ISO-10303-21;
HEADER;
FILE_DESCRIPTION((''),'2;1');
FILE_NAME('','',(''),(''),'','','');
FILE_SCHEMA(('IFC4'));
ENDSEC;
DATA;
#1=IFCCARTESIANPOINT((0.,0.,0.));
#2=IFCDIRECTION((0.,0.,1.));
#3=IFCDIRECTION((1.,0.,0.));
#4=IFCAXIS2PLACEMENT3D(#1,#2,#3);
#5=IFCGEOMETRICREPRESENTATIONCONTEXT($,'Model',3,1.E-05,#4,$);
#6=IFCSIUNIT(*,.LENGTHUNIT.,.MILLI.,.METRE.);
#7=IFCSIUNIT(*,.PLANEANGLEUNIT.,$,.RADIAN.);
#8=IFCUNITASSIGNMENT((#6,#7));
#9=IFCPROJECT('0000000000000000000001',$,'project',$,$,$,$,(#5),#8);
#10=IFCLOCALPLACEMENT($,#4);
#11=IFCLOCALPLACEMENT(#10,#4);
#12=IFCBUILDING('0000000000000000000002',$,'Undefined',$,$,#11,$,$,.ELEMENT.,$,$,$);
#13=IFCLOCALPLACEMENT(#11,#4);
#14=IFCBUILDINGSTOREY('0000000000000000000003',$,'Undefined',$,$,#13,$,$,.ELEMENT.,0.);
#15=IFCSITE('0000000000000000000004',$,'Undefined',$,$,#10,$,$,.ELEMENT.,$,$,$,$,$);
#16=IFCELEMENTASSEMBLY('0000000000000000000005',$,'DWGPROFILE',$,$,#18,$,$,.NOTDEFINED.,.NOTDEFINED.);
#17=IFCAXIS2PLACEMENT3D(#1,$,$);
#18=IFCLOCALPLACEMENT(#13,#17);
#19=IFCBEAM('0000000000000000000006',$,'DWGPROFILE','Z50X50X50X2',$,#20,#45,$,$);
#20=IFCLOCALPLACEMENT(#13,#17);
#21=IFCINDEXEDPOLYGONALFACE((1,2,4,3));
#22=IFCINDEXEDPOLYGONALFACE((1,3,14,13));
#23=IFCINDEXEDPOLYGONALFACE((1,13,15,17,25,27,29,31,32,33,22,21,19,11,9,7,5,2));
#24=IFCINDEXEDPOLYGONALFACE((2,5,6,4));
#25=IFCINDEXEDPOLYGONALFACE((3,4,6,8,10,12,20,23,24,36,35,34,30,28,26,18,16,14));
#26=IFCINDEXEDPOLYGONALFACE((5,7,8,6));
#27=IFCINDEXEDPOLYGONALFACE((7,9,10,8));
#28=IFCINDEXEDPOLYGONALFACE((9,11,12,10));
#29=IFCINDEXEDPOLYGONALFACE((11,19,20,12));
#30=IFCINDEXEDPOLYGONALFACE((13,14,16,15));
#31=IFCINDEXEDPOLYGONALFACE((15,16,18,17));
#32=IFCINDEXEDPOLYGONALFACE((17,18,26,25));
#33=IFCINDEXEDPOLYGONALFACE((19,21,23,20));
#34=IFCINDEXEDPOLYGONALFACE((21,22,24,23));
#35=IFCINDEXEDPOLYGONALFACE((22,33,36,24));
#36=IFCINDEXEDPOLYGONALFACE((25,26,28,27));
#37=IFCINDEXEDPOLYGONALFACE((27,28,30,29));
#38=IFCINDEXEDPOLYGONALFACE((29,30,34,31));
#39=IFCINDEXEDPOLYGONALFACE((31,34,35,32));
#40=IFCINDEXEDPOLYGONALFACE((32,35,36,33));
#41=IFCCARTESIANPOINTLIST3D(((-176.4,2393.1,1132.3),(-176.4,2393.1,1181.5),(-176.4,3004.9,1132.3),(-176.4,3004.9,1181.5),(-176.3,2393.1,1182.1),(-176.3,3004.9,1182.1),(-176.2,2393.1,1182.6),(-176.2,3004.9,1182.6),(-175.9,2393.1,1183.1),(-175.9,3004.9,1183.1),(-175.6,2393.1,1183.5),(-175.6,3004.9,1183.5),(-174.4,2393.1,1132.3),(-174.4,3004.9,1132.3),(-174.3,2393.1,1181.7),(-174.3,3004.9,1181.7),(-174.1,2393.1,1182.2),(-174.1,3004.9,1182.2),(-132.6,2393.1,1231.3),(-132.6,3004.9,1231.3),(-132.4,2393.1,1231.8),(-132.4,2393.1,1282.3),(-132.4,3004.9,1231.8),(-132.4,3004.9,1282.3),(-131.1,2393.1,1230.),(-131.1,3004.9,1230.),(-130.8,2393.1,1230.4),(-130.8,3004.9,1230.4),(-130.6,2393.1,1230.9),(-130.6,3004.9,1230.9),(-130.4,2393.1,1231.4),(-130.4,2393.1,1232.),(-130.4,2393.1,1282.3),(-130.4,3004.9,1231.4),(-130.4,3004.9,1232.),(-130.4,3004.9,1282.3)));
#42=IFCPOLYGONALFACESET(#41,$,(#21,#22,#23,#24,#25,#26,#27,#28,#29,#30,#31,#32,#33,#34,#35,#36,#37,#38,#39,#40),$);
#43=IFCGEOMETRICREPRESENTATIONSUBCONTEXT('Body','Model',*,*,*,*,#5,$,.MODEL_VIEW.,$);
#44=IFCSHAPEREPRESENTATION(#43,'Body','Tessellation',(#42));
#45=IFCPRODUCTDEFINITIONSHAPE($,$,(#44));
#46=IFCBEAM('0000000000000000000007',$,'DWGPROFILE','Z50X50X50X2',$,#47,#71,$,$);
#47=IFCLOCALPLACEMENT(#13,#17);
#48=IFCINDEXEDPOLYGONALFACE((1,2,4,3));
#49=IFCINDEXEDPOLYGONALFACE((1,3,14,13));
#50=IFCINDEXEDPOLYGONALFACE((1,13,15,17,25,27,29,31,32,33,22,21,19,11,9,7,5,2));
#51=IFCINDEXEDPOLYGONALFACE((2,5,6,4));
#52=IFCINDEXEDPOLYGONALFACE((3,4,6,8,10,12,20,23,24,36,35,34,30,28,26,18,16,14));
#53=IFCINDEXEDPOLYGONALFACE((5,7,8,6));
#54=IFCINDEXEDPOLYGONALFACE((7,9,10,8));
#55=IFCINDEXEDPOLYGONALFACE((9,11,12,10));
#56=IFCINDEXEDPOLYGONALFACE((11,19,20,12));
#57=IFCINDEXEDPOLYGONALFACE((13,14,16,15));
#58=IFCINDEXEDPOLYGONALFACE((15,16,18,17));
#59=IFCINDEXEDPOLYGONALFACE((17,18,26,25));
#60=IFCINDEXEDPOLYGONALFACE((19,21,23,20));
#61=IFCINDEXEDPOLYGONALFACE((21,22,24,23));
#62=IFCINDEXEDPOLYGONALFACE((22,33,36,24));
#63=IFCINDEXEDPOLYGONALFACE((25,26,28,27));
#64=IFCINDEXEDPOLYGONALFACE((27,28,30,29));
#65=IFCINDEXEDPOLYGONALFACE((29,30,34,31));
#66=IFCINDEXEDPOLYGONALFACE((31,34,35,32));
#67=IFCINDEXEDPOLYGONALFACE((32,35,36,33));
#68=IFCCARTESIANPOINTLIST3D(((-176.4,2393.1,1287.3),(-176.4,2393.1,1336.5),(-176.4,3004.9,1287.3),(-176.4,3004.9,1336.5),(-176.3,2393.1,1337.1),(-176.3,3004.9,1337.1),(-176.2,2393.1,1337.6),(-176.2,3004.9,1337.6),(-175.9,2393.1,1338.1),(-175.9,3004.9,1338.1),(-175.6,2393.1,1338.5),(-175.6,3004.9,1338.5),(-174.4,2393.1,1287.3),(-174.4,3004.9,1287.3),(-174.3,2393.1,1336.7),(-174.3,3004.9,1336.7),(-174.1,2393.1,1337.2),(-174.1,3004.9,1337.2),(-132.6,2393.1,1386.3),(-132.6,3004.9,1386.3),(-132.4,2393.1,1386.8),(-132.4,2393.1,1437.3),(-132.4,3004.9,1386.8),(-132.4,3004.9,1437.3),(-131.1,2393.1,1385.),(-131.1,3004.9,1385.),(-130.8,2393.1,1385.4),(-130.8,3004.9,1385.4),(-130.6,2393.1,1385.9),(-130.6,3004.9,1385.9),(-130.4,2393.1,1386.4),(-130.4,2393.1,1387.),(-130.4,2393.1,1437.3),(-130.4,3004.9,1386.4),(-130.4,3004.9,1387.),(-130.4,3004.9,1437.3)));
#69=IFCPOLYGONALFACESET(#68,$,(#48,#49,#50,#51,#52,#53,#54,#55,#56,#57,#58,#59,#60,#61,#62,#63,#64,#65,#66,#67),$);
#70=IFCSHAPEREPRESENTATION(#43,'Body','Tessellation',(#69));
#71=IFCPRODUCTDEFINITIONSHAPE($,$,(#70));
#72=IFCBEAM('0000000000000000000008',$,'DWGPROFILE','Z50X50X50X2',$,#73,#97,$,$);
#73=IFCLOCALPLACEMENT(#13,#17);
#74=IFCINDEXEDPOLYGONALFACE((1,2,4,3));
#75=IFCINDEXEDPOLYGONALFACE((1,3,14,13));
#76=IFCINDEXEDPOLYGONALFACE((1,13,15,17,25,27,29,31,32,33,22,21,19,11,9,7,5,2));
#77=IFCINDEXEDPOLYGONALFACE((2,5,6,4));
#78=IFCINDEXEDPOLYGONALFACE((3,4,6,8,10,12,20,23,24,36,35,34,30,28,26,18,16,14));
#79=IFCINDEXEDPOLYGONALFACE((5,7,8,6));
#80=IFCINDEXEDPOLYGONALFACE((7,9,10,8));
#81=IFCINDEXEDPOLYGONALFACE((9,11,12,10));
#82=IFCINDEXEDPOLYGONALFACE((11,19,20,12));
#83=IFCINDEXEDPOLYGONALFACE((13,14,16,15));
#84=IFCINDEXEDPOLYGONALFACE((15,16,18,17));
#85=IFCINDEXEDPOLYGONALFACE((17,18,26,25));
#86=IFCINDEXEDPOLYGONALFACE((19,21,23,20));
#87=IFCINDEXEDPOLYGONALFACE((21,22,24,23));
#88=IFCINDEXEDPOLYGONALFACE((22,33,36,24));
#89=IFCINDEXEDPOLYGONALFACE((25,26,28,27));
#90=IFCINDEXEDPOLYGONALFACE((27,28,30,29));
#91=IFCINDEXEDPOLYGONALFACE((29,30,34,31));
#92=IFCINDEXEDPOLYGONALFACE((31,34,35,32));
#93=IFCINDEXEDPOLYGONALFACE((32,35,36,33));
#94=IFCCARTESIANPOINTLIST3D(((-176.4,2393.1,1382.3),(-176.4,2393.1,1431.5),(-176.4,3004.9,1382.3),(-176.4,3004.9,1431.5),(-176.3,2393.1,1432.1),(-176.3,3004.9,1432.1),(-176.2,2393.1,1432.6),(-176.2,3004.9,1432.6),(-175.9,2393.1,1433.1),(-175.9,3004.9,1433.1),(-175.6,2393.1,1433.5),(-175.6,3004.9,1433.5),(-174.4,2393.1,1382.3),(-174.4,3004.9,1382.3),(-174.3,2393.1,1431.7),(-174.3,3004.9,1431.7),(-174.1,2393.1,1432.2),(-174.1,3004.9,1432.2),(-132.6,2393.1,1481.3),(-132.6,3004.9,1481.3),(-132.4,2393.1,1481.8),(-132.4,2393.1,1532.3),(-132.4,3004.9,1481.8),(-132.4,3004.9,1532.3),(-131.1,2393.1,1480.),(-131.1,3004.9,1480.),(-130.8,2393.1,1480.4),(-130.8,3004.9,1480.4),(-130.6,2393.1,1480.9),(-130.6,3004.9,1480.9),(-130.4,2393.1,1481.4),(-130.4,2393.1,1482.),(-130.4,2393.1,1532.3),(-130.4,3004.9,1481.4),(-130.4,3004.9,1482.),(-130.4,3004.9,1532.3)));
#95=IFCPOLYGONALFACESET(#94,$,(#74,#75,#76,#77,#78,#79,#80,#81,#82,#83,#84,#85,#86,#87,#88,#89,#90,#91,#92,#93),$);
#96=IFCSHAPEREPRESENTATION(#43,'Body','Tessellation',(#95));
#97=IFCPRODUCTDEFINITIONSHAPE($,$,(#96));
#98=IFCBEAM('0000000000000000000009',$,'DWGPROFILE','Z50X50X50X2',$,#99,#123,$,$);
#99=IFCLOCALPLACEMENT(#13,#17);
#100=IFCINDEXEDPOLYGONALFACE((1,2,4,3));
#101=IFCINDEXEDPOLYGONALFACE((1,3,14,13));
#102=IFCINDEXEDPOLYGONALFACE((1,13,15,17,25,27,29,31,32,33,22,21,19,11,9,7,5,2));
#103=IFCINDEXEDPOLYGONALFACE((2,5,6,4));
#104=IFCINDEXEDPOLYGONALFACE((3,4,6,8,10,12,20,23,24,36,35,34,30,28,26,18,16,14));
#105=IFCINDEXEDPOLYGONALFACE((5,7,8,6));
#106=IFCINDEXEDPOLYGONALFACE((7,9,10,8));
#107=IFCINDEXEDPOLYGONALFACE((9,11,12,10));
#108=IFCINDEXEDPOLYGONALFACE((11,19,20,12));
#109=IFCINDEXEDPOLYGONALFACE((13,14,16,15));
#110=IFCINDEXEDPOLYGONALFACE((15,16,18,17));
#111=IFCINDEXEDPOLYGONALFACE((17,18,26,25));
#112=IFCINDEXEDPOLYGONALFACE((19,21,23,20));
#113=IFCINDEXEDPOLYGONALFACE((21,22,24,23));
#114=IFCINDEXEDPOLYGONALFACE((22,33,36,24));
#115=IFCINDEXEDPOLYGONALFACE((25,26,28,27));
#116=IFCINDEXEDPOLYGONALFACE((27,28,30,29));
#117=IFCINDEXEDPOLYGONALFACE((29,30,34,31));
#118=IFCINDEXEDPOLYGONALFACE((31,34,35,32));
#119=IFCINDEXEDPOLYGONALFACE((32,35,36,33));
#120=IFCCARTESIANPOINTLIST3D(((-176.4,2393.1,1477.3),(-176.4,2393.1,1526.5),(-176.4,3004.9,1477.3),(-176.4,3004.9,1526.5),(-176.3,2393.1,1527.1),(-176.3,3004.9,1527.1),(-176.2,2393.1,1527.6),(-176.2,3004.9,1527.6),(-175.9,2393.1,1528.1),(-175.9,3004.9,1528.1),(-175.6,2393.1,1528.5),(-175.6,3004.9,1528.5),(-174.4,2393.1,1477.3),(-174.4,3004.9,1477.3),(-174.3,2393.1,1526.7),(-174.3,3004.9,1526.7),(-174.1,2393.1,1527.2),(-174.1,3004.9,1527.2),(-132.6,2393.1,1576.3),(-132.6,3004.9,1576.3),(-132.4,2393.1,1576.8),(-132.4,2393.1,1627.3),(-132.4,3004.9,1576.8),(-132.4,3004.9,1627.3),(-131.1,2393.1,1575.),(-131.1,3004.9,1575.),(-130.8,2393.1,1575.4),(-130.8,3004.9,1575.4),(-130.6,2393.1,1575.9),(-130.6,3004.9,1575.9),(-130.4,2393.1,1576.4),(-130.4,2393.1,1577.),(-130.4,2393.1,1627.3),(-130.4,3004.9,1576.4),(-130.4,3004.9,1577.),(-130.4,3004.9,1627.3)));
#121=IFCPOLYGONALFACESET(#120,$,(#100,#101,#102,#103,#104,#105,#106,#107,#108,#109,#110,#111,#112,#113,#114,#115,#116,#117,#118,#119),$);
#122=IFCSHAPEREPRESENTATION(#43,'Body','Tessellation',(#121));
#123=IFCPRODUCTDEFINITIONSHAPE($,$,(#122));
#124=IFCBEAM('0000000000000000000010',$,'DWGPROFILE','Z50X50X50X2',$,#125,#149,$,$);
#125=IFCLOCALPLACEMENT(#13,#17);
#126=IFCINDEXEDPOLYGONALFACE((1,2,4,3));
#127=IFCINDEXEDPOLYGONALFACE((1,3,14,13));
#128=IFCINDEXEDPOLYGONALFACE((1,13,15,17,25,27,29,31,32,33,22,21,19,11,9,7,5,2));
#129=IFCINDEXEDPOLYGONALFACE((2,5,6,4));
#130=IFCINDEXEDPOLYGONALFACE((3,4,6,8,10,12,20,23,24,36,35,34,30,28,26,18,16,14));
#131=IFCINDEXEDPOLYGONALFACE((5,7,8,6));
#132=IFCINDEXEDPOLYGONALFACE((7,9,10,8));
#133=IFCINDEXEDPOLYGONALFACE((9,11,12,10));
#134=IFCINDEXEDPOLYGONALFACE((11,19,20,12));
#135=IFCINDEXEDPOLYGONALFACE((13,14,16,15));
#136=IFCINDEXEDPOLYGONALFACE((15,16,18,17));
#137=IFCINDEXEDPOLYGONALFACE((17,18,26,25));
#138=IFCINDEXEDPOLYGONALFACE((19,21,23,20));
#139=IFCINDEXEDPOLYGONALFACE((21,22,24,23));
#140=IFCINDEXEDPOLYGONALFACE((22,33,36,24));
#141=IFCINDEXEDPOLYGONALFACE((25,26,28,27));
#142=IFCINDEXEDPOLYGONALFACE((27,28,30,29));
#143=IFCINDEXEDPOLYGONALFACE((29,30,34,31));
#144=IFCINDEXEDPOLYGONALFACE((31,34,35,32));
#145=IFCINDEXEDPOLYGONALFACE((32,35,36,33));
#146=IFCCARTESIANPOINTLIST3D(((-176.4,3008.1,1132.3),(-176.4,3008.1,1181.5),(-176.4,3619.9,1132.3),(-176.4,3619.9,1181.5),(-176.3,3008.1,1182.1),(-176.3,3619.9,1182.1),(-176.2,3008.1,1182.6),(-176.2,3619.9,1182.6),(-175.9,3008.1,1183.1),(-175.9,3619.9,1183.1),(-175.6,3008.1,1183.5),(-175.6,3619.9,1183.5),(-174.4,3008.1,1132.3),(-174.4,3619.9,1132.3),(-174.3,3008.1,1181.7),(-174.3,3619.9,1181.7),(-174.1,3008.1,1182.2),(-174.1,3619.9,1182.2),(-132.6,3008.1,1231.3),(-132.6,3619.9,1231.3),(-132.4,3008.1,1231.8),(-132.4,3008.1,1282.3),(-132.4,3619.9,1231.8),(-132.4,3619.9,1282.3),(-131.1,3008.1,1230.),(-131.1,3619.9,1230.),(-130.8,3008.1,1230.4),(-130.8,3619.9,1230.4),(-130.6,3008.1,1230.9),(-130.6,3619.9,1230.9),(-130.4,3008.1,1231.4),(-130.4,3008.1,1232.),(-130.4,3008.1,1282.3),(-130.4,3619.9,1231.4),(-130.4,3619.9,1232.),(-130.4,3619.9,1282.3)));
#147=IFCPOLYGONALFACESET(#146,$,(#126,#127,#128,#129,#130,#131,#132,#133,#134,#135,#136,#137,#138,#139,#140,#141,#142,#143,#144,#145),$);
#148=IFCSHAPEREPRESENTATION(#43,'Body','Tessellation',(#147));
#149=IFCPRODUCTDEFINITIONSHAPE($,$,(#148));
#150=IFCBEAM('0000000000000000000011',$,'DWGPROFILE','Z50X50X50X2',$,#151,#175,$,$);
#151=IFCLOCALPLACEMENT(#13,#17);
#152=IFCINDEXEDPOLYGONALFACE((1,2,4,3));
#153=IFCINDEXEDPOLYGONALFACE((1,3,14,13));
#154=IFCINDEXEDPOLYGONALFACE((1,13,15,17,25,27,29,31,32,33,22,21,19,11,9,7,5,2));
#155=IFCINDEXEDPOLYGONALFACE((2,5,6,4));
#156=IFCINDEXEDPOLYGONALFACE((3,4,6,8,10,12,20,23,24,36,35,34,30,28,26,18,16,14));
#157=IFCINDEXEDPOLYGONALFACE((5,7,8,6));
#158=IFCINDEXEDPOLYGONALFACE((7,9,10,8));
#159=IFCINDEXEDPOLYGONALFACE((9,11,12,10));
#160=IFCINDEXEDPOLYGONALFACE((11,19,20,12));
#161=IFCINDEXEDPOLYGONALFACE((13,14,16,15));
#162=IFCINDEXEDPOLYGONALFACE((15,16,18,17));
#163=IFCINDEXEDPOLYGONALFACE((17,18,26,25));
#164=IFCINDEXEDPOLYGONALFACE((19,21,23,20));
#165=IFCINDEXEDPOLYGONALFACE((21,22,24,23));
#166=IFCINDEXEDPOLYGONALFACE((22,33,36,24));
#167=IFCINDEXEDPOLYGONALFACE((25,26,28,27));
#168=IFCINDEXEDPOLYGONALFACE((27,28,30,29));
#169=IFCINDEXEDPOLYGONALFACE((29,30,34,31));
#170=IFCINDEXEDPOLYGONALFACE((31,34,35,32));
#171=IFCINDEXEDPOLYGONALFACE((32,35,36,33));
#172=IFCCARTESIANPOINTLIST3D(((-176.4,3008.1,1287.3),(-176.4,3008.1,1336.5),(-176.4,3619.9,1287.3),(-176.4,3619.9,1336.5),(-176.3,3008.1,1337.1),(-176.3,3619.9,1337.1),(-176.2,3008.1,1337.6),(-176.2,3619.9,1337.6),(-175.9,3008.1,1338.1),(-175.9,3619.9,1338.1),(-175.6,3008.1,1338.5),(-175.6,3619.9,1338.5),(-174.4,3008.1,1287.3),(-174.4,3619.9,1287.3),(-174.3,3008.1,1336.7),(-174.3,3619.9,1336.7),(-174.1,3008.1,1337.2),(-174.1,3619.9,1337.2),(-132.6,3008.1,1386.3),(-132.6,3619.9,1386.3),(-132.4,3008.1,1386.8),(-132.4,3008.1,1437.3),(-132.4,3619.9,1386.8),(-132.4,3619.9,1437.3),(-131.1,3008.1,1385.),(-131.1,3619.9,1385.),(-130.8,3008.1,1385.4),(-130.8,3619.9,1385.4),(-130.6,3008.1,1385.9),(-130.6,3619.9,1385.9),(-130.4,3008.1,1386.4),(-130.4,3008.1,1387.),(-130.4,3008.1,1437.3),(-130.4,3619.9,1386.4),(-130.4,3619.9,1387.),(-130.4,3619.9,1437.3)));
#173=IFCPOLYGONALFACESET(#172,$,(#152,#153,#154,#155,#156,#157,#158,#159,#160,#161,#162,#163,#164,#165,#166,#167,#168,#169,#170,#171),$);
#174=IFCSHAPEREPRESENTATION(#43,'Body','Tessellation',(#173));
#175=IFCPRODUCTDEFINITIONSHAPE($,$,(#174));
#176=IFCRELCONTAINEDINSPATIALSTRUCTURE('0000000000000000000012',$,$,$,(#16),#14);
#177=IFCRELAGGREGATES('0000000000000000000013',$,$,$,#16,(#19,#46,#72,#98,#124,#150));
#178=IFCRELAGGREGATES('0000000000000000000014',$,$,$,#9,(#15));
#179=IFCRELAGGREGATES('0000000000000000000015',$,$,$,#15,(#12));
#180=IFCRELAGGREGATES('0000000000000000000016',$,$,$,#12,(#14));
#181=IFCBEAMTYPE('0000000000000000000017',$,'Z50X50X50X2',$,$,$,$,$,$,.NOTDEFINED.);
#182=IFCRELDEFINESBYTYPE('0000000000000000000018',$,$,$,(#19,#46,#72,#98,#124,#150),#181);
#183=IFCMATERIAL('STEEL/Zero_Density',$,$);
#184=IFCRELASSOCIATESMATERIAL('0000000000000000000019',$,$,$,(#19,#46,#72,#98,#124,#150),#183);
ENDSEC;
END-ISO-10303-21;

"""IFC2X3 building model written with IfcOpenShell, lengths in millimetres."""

from ifc_helpers import new_model, si_unit, frame, origin_with_axes, place, context, subcontext, project, spatial, polyline, outline, extrude, material, type_object, element, aggregate, save


model = new_model("IFC2X3")

# Units and contexts
model_context = context("Model", 3, precision=1e-05, world=origin_with_axes())
body_context = subcontext(model_context, "Body", "Model", "MODEL_VIEW")
ifc_project = project(units=[si_unit("LENGTHUNIT", "METRE", prefix="MILLI"), si_unit("PLANEANGLEUNIT", "RADIAN")], contexts=[model_context])

# Site, building, storey
site_placement = place(None, origin_with_axes())
site = spatial("IfcSite", under=ifc_project, at=site_placement, Name="Undefined", CompositionType="ELEMENT")
building_placement = place(site_placement, origin_with_axes())
building = spatial("IfcBuilding", under=site, at=building_placement, Name="Undefined", CompositionType="ELEMENT")
storey_placement = place(building_placement, origin_with_axes())
storey = spatial("IfcBuildingStorey", under=building, at=storey_placement, Name="Undefined", CompositionType="ELEMENT", Elevation=0.0)

# Element assembly, beams
assembly_1_placement = place(storey_placement, origin_with_axes())
assembly_1 = element("IfcElementAssembly", 1, at=assembly_1_placement, inside=storey, Name="DWGPROFILE", AssemblyPlace="NOTDEFINED", PredefinedType="NOTDEFINED")
ifc_material_1 = material(Name="STEEL/Zero_Density")
beam_type_1 = type_object("IfcBeamType", Name="Z50X50X50X2", PredefinedType="NOTDEFINED")
beam_1_placement = place(assembly_1_placement, frame((-153.4, 3004.9, 1207.3), z_axis=(0.0, 0.0, 1.0), x_axis=(0.0, -1.0, 0.0)))
beam_1 = element("IfcBeam", 2, at=beam_1_placement, type_object=beam_type_1, material=ifc_material_1, Name="DWGPROFILE", Description="Z50X50X50X2", context=body_context, shape_type="SweptSolid", body=[
    extrude(outline(polyline([(-22.9, 24.1), (-23.0, 24.7), (-23.0, 75.0), (-21.0, 75.0), (-21.0, 24.5), (-20.7, 24.0), (22.2, -23.8), (22.6, -24.2), (22.8, -24.7), (22.9, -25.2), (23.0, -25.8), (23.0, -75.0), (21.0, -75.0), (21.0, -25.6), (20.7, -25.1), (-22.2, 22.6), (-22.6, 23.1), (-22.8, 23.6), (-22.9, 24.1)])), frame((611.8, 0.0, 0.0), z_axis=(-1.0, 0.0, 0.0), x_axis=(0.0, -1.0, 0.0)), (0.0, 0.0, 1.0), 611.8),
])
beam_2_placement = place(assembly_1_placement, frame((-153.4, 3004.9, 1362.3), z_axis=(0.0, 0.0, 1.0), x_axis=(0.0, -1.0, 0.0)))
beam_2 = element("IfcBeam", 3, at=beam_2_placement, type_object=beam_type_1, material=ifc_material_1, Name="DWGPROFILE", Description="Z50X50X50X2", context=body_context, shape_type="SweptSolid", body=[
    extrude(outline(polyline([(-22.9, 24.1), (-23.0, 24.7), (-23.0, 75.0), (-21.0, 75.0), (-21.0, 24.5), (-20.7, 24.0), (22.2, -23.8), (22.6, -24.2), (22.8, -24.7), (22.9, -25.2), (23.0, -25.8), (23.0, -75.0), (21.0, -75.0), (21.0, -25.6), (20.7, -25.1), (-22.2, 22.6), (-22.6, 23.1), (-22.8, 23.6), (-22.9, 24.1)])), frame((611.8, 0.0, 0.0), z_axis=(-1.0, 0.0, 0.0), x_axis=(0.0, -1.0, 0.0)), (0.0, 0.0, 1.0), 611.8),
])
beam_3_placement = place(assembly_1_placement, frame((-153.4, 3004.9, 1457.3), z_axis=(0.0, 0.0, 1.0), x_axis=(0.0, -1.0, 0.0)))
beam_3 = element("IfcBeam", 4, at=beam_3_placement, type_object=beam_type_1, material=ifc_material_1, Name="DWGPROFILE", Description="Z50X50X50X2", context=body_context, shape_type="SweptSolid", body=[
    extrude(outline(polyline([(-22.9, 24.1), (-23.0, 24.7), (-23.0, 75.0), (-21.0, 75.0), (-21.0, 24.5), (-20.7, 24.0), (22.2, -23.8), (22.6, -24.2), (22.8, -24.7), (22.9, -25.2), (23.0, -25.8), (23.0, -75.0), (21.0, -75.0), (21.0, -25.6), (20.7, -25.1), (-22.2, 22.6), (-22.6, 23.1), (-22.8, 23.6), (-22.9, 24.1)])), frame((611.8, 0.0, 0.0), z_axis=(-1.0, 0.0, 0.0), x_axis=(0.0, -1.0, 0.0)), (0.0, 0.0, 1.0), 611.8),
])
beam_4_placement = place(assembly_1_placement, frame((-153.4, 3004.9, 1552.3), z_axis=(0.0, 0.0, 1.0), x_axis=(0.0, -1.0, 0.0)))
beam_4 = element("IfcBeam", 5, at=beam_4_placement, type_object=beam_type_1, material=ifc_material_1, Name="DWGPROFILE", Description="Z50X50X50X2", context=body_context, shape_type="SweptSolid", body=[
    extrude(outline(polyline([(-22.9, 24.1), (-23.0, 24.7), (-23.0, 75.0), (-21.0, 75.0), (-21.0, 24.5), (-20.7, 24.0), (22.2, -23.8), (22.6, -24.2), (22.8, -24.7), (22.9, -25.2), (23.0, -25.8), (23.0, -75.0), (21.0, -75.0), (21.0, -25.6), (20.7, -25.1), (-22.2, 22.6), (-22.6, 23.1), (-22.8, 23.6), (-22.9, 24.1)])), frame((611.8, 0.0, 0.0), z_axis=(-1.0, 0.0, 0.0), x_axis=(0.0, -1.0, 0.0)), (0.0, 0.0, 1.0), 611.8),
])
beam_5_placement = place(assembly_1_placement, frame((-153.4, 3619.9, 1207.3), z_axis=(0.0, 0.0, 1.0), x_axis=(0.0, -1.0, 0.0)))
beam_5 = element("IfcBeam", 6, at=beam_5_placement, type_object=beam_type_1, material=ifc_material_1, Name="DWGPROFILE", Description="Z50X50X50X2", context=body_context, shape_type="SweptSolid", body=[
    extrude(outline(polyline([(-22.9, 24.1), (-23.0, 24.7), (-23.0, 75.0), (-21.0, 75.0), (-21.0, 24.5), (-20.7, 24.0), (22.2, -23.8), (22.6, -24.2), (22.8, -24.7), (22.9, -25.2), (23.0, -25.8), (23.0, -75.0), (21.0, -75.0), (21.0, -25.6), (20.7, -25.1), (-22.2, 22.6), (-22.6, 23.1), (-22.8, 23.6), (-22.9, 24.1)])), frame((611.8, 0.0, 0.0), z_axis=(-1.0, 0.0, 0.0), x_axis=(0.0, -1.0, 0.0)), (0.0, 0.0, 1.0), 611.8),
])
beam_6_placement = place(assembly_1_placement, frame((-153.4, 3619.9, 1362.3), z_axis=(0.0, 0.0, 1.0), x_axis=(0.0, -1.0, 0.0)))
beam_6 = element("IfcBeam", 7, at=beam_6_placement, type_object=beam_type_1, material=ifc_material_1, Name="DWGPROFILE", Description="Z50X50X50X2", context=body_context, shape_type="SweptSolid", body=[
    extrude(outline(polyline([(-22.9, 24.1), (-23.0, 24.7), (-23.0, 75.0), (-21.0, 75.0), (-21.0, 24.5), (-20.7, 24.0), (22.2, -23.8), (22.6, -24.2), (22.8, -24.7), (22.9, -25.2), (23.0, -25.8), (23.0, -75.0), (21.0, -75.0), (21.0, -25.6), (20.7, -25.1), (-22.2, 22.6), (-22.6, 23.1), (-22.8, 23.6), (-22.9, 24.1)])), frame((611.8, 0.0, 0.0), z_axis=(-1.0, 0.0, 0.0), x_axis=(0.0, -1.0, 0.0)), (0.0, 0.0, 1.0), 611.8),
])
aggregate(assembly_1, [beam_1, beam_2, beam_3, beam_4, beam_5, beam_6])

save(model, "model.ifc")
